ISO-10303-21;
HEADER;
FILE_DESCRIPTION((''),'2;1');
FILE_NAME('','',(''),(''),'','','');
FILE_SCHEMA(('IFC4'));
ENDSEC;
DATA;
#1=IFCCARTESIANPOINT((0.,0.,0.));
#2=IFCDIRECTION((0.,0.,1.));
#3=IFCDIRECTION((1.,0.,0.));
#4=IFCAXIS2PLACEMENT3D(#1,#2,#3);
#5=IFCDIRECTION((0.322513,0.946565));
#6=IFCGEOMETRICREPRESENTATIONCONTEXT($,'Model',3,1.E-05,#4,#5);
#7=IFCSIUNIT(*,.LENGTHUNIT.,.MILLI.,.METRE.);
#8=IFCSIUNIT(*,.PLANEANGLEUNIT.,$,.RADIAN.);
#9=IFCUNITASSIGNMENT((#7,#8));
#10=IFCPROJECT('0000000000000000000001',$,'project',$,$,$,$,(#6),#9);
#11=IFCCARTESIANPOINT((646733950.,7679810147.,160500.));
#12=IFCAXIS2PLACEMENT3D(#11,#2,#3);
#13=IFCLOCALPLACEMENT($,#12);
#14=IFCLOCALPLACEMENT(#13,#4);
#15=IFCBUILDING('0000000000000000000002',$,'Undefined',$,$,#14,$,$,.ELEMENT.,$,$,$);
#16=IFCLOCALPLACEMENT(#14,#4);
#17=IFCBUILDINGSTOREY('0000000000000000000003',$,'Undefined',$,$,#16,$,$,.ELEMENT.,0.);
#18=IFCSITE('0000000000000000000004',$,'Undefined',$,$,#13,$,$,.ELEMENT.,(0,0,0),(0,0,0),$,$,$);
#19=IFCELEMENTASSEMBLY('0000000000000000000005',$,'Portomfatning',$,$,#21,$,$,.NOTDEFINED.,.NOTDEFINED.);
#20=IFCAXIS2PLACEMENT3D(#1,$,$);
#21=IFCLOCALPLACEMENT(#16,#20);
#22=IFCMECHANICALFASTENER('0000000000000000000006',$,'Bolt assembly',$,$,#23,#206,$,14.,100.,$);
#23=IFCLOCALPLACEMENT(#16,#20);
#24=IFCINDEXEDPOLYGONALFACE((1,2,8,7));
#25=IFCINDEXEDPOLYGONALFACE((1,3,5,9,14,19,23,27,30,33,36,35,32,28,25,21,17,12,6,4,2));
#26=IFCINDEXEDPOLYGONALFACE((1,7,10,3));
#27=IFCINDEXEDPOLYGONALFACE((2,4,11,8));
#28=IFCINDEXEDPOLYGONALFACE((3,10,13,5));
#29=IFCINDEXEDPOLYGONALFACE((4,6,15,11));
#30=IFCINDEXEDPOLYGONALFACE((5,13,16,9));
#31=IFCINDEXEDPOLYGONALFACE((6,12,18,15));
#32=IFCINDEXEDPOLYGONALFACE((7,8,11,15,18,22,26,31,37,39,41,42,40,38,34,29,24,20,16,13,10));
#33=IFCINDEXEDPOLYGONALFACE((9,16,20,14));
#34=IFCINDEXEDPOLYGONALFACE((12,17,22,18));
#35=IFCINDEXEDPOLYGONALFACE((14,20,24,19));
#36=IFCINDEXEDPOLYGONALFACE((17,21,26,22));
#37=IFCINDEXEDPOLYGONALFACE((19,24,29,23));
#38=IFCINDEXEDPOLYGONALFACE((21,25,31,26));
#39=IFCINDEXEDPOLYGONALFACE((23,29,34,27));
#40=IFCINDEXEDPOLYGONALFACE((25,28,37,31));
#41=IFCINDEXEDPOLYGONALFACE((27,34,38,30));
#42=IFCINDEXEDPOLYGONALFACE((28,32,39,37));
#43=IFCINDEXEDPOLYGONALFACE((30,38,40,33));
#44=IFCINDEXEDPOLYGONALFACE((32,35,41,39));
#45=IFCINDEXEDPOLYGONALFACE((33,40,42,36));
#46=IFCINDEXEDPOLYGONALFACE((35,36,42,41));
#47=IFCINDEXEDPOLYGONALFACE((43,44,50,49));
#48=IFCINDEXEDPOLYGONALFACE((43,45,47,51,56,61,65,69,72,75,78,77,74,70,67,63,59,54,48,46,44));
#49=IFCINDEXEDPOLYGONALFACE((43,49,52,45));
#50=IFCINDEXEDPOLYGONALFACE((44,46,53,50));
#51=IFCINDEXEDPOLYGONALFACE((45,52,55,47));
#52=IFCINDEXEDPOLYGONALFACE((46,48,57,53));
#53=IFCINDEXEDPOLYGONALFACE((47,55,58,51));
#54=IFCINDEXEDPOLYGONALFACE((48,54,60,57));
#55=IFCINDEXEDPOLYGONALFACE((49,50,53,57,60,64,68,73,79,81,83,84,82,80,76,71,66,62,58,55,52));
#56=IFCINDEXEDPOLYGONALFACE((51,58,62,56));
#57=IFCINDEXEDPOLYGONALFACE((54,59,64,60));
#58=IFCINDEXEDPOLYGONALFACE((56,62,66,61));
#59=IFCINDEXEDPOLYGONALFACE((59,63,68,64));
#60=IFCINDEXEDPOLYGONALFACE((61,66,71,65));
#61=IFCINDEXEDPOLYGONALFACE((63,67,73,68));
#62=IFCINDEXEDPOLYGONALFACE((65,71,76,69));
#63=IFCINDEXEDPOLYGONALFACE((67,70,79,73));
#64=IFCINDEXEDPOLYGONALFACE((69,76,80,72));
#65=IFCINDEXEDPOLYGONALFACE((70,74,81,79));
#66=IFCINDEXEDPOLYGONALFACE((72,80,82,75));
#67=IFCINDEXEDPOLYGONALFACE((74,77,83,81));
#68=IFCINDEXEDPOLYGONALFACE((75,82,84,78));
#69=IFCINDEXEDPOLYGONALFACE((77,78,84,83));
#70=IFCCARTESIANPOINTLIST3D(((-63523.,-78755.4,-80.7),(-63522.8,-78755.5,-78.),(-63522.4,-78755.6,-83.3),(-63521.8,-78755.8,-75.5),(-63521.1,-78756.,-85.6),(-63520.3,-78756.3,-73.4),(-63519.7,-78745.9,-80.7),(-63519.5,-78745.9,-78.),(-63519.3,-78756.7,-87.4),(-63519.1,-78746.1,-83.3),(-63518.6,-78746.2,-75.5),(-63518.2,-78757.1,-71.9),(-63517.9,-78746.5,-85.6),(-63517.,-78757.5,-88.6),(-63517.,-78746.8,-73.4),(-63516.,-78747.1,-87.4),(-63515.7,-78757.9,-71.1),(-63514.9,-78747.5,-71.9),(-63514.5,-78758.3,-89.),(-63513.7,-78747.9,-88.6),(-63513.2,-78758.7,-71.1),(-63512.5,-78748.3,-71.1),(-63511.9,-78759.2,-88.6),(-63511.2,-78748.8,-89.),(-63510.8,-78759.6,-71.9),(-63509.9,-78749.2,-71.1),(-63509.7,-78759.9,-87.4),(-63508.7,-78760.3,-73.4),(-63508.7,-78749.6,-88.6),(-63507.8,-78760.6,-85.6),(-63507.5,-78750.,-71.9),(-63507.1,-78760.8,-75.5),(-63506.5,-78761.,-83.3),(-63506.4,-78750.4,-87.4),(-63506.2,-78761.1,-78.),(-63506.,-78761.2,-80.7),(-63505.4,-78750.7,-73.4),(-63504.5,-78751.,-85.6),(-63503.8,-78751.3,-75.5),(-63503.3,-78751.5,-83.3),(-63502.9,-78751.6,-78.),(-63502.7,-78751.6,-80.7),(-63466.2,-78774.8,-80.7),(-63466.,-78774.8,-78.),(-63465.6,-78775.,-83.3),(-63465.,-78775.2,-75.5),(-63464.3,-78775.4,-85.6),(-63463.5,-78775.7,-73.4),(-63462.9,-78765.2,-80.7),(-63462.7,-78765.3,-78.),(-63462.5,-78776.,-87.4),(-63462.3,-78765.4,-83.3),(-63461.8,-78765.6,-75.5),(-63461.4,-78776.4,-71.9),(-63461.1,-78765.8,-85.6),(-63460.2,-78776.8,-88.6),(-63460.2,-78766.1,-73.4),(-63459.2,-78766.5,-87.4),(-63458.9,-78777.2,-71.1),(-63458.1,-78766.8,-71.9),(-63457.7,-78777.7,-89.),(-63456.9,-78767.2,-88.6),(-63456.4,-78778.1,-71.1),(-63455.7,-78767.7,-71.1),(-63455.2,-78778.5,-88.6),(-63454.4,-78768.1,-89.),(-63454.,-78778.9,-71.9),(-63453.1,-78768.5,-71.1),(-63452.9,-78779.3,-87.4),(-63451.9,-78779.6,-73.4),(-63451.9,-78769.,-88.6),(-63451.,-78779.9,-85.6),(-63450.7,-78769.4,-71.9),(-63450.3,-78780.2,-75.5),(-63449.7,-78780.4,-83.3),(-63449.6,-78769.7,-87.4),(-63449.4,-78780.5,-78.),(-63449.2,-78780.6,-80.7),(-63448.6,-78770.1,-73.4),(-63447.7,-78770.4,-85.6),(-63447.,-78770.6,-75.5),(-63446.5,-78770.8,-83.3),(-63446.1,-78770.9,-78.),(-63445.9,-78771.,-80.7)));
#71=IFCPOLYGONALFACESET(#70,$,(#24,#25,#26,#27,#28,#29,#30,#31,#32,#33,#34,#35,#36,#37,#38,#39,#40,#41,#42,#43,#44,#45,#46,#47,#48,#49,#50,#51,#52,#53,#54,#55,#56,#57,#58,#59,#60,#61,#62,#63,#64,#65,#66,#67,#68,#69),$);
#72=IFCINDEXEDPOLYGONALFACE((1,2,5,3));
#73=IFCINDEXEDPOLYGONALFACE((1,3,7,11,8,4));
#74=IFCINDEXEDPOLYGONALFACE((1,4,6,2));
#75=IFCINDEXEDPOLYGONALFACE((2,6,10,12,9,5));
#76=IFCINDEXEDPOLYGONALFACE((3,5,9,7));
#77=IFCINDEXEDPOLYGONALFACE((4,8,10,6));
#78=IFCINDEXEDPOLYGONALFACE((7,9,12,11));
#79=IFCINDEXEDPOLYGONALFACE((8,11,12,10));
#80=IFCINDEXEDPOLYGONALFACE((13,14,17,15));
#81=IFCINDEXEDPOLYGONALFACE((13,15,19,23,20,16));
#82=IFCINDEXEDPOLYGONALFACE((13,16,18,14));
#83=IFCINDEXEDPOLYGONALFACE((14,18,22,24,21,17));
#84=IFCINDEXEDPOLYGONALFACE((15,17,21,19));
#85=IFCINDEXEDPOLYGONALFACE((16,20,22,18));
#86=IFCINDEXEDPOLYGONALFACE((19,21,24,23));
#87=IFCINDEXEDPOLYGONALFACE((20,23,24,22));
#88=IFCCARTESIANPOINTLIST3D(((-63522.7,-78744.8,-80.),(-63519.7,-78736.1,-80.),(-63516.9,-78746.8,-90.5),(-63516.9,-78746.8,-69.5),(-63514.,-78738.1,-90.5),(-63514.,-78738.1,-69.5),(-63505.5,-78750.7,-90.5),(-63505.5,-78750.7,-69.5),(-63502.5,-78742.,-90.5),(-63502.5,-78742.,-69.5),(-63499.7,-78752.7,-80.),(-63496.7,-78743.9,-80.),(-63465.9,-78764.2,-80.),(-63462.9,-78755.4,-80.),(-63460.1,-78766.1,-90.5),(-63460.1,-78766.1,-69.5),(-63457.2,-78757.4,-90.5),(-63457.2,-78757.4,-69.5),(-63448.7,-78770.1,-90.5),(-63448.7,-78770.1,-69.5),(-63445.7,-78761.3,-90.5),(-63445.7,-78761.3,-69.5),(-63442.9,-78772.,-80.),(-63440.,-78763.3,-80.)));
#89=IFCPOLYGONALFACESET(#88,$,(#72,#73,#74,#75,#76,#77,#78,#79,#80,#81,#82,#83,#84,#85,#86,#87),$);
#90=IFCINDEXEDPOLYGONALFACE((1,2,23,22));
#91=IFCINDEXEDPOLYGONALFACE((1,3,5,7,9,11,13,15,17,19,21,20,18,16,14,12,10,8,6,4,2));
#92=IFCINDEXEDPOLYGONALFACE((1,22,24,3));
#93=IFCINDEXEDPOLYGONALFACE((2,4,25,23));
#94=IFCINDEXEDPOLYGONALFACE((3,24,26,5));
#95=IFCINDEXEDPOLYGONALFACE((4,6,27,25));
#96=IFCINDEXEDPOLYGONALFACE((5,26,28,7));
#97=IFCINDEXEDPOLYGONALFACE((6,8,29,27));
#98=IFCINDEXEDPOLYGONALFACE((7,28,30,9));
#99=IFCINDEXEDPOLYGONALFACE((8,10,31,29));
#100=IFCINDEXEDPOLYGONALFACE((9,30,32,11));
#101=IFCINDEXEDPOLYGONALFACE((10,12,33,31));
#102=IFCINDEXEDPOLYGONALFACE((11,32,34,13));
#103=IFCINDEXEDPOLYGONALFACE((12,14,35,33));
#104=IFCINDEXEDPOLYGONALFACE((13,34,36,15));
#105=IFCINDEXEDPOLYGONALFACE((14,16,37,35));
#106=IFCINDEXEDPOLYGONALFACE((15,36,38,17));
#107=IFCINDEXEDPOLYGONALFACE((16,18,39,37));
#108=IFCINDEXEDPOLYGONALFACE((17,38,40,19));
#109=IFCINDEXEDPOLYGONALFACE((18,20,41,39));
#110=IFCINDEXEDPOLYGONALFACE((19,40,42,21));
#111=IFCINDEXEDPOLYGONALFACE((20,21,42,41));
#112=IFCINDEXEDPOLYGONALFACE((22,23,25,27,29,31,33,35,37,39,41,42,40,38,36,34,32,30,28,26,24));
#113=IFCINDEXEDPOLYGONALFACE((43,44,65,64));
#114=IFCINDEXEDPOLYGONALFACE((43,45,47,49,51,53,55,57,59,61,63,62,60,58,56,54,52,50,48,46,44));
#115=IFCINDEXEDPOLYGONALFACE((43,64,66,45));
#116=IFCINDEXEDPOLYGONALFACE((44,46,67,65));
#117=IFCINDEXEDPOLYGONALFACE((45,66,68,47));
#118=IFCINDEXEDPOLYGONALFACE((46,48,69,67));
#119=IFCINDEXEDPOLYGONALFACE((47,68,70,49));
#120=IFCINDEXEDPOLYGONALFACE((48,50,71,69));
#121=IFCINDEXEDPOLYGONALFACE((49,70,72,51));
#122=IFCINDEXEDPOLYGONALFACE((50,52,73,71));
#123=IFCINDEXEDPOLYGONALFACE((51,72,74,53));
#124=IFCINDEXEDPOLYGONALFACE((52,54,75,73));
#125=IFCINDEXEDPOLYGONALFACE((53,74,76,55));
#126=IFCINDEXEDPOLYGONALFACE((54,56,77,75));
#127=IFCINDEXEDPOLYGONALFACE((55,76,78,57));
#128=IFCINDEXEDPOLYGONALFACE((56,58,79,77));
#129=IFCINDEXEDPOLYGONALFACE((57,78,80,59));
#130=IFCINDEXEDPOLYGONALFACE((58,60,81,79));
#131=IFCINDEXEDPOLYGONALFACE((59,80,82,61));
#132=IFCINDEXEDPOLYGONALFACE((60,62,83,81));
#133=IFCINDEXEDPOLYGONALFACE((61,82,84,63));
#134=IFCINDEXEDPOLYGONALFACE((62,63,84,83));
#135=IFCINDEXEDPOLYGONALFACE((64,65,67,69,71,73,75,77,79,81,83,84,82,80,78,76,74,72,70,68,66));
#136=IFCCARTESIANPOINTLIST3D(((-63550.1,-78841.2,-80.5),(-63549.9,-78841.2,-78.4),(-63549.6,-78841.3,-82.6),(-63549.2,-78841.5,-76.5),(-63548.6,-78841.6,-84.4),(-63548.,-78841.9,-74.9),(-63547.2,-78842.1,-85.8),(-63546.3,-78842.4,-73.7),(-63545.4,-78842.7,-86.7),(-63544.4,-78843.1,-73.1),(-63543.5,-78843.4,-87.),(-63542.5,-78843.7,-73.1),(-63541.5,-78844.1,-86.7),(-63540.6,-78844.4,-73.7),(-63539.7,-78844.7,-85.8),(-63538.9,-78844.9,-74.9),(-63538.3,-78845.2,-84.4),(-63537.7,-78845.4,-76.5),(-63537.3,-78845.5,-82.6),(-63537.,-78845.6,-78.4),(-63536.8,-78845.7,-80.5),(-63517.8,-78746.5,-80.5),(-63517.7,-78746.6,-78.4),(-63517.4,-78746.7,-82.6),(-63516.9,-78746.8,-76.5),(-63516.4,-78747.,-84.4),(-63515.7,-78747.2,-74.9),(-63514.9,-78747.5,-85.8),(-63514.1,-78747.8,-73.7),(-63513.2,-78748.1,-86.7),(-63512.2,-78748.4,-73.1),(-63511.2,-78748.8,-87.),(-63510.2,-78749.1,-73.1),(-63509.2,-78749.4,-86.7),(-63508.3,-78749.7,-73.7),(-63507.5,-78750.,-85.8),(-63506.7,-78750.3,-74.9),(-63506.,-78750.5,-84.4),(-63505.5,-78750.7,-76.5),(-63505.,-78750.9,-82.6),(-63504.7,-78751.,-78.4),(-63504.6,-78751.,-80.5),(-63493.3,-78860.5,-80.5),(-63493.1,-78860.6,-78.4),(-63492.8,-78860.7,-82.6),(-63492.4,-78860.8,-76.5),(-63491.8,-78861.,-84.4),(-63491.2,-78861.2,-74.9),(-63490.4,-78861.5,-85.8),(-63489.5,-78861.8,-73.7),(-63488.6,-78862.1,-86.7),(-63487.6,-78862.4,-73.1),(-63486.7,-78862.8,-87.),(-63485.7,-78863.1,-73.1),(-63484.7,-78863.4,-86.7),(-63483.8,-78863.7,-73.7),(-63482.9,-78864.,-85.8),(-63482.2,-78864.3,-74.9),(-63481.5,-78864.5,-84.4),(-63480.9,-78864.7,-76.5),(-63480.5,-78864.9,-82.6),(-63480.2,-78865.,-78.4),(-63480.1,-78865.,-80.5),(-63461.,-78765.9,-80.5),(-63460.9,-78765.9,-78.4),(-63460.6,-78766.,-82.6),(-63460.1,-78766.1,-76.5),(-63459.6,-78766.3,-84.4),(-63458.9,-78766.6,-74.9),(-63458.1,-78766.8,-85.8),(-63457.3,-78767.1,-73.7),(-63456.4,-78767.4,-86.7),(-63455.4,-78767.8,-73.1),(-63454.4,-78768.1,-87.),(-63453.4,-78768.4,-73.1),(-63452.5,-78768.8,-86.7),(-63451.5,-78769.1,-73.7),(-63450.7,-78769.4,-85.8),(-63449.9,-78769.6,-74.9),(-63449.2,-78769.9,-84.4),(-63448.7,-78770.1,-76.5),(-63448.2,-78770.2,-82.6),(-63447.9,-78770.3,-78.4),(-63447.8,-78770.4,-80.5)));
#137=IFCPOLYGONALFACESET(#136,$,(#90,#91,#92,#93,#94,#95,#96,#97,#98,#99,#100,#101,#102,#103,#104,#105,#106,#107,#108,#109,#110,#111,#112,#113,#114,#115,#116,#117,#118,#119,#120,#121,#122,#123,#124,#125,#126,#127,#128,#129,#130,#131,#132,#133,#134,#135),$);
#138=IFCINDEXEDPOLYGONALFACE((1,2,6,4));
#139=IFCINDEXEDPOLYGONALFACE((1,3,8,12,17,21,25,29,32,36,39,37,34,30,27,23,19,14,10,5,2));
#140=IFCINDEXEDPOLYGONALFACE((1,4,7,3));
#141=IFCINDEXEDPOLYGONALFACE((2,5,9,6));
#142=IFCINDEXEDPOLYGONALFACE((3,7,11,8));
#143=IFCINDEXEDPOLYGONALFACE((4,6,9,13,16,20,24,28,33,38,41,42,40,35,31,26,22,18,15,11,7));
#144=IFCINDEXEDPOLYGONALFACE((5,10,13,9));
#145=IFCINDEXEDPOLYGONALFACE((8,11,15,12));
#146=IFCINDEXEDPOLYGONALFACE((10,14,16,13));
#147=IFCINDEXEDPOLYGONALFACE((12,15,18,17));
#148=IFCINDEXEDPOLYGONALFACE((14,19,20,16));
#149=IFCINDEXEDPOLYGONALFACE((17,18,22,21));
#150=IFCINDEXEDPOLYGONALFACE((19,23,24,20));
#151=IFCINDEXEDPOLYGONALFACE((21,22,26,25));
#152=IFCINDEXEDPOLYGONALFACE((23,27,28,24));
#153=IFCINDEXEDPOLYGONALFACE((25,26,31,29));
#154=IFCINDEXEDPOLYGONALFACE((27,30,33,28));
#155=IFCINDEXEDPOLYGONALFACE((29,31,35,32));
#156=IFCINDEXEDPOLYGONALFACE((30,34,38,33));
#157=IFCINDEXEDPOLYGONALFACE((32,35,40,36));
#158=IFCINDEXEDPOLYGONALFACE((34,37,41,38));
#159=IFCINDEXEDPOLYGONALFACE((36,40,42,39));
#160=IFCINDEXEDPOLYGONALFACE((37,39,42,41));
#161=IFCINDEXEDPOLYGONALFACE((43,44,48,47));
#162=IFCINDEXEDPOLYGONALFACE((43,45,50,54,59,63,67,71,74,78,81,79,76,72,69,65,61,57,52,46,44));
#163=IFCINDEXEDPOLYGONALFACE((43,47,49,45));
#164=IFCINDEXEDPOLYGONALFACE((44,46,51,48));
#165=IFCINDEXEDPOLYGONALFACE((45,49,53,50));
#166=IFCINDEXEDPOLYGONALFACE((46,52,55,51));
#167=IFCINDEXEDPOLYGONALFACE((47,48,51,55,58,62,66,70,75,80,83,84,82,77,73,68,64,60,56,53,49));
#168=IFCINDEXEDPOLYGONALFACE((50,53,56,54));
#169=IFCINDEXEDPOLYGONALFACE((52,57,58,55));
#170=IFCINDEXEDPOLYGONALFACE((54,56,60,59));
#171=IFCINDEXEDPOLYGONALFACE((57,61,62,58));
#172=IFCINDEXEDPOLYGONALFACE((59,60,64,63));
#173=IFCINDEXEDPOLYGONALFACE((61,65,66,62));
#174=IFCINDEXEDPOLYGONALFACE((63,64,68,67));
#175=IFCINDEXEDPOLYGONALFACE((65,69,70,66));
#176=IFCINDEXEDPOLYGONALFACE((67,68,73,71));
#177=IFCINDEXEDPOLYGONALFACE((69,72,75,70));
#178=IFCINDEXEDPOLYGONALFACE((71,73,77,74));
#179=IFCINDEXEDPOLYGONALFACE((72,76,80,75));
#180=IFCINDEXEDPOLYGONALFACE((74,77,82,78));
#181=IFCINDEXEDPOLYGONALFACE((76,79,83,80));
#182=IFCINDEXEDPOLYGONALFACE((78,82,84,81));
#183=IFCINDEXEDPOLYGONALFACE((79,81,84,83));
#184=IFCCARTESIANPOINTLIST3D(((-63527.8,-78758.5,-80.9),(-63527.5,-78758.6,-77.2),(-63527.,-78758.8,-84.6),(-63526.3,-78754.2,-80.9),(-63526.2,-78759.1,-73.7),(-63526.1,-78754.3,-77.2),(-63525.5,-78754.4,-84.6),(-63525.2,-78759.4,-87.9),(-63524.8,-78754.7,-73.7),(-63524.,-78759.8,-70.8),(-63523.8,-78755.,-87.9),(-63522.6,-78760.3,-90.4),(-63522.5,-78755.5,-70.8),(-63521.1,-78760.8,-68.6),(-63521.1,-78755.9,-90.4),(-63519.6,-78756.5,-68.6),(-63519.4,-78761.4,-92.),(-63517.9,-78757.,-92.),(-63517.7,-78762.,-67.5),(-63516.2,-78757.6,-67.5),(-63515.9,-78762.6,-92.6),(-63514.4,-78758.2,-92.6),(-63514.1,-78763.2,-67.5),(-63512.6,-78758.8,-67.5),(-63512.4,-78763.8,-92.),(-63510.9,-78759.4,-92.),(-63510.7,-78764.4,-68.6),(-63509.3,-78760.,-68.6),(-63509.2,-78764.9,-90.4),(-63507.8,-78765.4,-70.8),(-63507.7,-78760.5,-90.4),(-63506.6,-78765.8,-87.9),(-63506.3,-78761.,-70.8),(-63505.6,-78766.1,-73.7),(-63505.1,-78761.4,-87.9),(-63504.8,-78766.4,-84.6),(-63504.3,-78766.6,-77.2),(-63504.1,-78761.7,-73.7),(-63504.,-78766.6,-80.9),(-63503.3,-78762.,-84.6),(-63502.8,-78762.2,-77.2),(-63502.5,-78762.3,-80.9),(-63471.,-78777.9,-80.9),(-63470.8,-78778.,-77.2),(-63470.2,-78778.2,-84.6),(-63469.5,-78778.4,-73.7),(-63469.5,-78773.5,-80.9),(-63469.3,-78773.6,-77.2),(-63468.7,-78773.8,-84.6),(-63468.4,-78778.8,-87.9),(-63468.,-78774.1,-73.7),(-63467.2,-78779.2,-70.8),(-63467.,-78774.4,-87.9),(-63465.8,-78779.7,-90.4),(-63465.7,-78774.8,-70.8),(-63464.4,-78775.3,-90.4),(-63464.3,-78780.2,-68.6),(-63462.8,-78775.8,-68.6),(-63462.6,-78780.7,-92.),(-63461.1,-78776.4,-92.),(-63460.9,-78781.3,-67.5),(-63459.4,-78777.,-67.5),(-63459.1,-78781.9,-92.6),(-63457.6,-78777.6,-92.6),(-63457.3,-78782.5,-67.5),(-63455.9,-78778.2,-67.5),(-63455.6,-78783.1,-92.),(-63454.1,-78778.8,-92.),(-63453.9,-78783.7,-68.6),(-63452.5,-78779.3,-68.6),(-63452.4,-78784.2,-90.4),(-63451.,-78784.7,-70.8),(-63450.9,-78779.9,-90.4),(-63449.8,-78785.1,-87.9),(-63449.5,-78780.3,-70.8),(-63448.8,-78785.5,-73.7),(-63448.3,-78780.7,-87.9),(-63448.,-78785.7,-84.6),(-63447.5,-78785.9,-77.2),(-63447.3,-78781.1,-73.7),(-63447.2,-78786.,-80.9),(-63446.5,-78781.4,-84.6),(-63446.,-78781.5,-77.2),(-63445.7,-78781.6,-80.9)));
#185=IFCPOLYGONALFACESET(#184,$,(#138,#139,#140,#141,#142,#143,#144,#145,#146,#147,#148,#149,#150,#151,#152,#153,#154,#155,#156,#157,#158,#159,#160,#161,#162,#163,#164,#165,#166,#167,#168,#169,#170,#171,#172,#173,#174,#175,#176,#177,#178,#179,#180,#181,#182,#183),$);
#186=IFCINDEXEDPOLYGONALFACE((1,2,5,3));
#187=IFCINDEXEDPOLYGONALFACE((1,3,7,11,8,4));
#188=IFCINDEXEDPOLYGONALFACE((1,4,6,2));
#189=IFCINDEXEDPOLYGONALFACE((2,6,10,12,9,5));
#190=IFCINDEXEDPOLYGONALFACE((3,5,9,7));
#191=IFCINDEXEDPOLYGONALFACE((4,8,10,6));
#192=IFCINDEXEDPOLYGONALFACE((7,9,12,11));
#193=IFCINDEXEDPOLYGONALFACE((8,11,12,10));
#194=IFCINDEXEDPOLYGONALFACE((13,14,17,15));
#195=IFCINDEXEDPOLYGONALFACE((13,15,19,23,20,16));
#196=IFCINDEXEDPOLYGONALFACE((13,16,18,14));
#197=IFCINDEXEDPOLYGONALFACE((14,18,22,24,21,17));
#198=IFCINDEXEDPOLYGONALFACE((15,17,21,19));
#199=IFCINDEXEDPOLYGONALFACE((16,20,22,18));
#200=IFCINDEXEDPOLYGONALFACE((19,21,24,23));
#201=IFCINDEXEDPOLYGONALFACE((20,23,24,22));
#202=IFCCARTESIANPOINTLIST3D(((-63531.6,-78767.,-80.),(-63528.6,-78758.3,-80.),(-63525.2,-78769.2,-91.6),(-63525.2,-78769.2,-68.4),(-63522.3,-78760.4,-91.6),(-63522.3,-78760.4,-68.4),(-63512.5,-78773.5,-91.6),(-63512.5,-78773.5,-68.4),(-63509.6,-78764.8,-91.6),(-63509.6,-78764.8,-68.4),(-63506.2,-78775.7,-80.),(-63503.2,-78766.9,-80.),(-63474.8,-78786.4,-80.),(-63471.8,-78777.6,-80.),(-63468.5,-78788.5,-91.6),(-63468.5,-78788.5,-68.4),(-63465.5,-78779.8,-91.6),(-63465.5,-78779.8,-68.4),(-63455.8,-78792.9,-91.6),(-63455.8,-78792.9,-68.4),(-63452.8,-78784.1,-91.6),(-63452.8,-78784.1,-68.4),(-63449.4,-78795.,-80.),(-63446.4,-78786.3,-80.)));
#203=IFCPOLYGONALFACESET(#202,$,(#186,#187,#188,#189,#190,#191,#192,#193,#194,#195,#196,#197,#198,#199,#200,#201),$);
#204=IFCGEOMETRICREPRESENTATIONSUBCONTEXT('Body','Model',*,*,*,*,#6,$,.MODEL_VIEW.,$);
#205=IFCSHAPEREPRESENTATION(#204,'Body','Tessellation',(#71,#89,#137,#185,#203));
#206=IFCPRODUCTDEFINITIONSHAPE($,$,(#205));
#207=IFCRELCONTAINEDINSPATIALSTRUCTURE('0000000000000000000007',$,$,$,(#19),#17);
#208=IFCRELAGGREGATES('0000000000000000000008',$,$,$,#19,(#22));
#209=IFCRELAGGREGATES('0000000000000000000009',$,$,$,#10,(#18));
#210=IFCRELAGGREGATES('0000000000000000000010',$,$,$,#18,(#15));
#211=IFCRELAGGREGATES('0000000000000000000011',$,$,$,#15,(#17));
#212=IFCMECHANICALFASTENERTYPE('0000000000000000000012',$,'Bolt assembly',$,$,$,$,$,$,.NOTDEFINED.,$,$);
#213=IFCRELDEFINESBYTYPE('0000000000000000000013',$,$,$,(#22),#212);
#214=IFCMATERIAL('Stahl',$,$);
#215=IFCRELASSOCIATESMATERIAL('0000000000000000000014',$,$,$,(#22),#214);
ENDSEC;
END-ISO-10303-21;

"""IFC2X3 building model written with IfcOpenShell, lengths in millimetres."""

from ifc_helpers import new_model, si_unit, direction, frame, origin_with_axes, origin_2d_with_axis, place, context, subcontext, project, spatial, polyline, circle, outline, extrude, source, transform, mapped, material, type_object, element, aggregate, save


model = new_model("IFC2X3")

# Units and contexts
model_context = context("Model", 3, precision=1e-05, world=origin_with_axes(), true_north=direction((0.322513, 0.946565)))
body_context = subcontext(model_context, "Body", "Model", "MODEL_VIEW")
ifc_project = project(units=[si_unit("LENGTHUNIT", "METRE", prefix="MILLI"), si_unit("PLANEANGLEUNIT", "RADIAN")], contexts=[model_context])

# Site, building, storey
site_placement = place(None, frame((646733950.0, 7679810147.0, 160500.0), z_axis=(0.0, 0.0, 1.0), x_axis=(1.0, 0.0, 0.0)))
site = spatial("IfcSite", under=ifc_project, at=site_placement, Name="Undefined", CompositionType="ELEMENT", RefLatitude=(0, 0, 0), RefLongitude=(0, 0, 0))
building_placement = place(site_placement, origin_with_axes())
building = spatial("IfcBuilding", under=site, at=building_placement, Name="Undefined", CompositionType="ELEMENT")
storey_placement = place(building_placement, origin_with_axes())
storey = spatial("IfcBuildingStorey", under=building, at=storey_placement, Name="Undefined", CompositionType="ELEMENT", Elevation=0.0)

# Element assembly
assembly_1_placement = place(storey_placement, origin_with_axes())
assembly_1 = element("IfcElementAssembly", 1, at=assembly_1_placement, inside=storey, Name="Portomfatning", AssemblyPlace="NOTDEFINED", PredefinedType="NOTDEFINED")

# Mechanical fastener
mechanical_fastener_type = type_object("IfcMechanicalFastenerType", Name="Bolt assembly")
ifc_material_1 = material(Name="Stahl")
shared_shape_1 = source(origin_with_axes(), body_context, "Body", "SweptSolid", [
    extrude(circle(Radius=9.0, at=origin_2d_with_axis()), frame((0.0, -10.0, 0.0), z_axis=(0.0, 1.0, 0.0), x_axis=(1.0, 0.0, 0.0)), (0.0, 0.0, 1.0), 10.1),
    extrude(outline(polyline([(10.5, -6.1), (10.5, 6.1), (0.0, 12.1), (-10.5, 6.1), (-10.5, -6.1), (0.0, -12.1), (10.5, -6.1)])), frame((0.0, -19.2, 0.0), z_axis=(0.0, 1.0, 0.0), x_axis=(1.0, 0.0, 0.0)), (0.0, 0.0, 1.0), 9.2),
    extrude(circle(Radius=7.0, at=origin_2d_with_axis()), frame((0.0, -10.0, 0.0), z_axis=(0.0, 1.0, 0.0), x_axis=(1.0, 0.0, 0.0)), (0.0, 0.0, 1.0), 100.0),
    extrude(circle(Radius=12.6, at=origin_2d_with_axis()), frame((0.0, 0.0, 0.0), z_axis=(0.0, 1.0, 0.0), x_axis=(1.0, 0.0, 0.0)), (0.0, 0.0, 1.0), 4.6),
    extrude(outline(polyline([(11.6, -6.7), (11.6, 6.7), (0.0, 13.4), (-11.6, 6.7), (-11.6, -6.7), (0.0, -13.4), (11.6, -6.7)])), frame((0.0, 4.6, 0.0), z_axis=(0.0, 1.0, 0.0), x_axis=(1.0, 0.0, 0.0)), (0.0, 0.0, 1.0), 9.2),
])
mechanical_fastener_1_placement = place(assembly_1_placement, frame((-63486.0, -78767.9, -80.0), z_axis=(-0.946565, 0.322513, 0.000025), x_axis=(-0.000024, 0.000008, -1.0)))
mechanical_fastener_1 = element("IfcMechanicalFastener", 2, at=mechanical_fastener_1_placement, type_object=mechanical_fastener_type, material=ifc_material_1, Name="Bolt assembly", NominalDiameter=14.0, NominalLength=100.0, context=body_context, shape_type="MappedRepresentation", body=[
    mapped(shared_shape_1, transform((0.0, 0.0, -30.0))),
    mapped(shared_shape_1, transform((0.0, 0.0, 30.0))),
])
aggregate(assembly_1, [mechanical_fastener_1])

save(model, "model.ifc")
